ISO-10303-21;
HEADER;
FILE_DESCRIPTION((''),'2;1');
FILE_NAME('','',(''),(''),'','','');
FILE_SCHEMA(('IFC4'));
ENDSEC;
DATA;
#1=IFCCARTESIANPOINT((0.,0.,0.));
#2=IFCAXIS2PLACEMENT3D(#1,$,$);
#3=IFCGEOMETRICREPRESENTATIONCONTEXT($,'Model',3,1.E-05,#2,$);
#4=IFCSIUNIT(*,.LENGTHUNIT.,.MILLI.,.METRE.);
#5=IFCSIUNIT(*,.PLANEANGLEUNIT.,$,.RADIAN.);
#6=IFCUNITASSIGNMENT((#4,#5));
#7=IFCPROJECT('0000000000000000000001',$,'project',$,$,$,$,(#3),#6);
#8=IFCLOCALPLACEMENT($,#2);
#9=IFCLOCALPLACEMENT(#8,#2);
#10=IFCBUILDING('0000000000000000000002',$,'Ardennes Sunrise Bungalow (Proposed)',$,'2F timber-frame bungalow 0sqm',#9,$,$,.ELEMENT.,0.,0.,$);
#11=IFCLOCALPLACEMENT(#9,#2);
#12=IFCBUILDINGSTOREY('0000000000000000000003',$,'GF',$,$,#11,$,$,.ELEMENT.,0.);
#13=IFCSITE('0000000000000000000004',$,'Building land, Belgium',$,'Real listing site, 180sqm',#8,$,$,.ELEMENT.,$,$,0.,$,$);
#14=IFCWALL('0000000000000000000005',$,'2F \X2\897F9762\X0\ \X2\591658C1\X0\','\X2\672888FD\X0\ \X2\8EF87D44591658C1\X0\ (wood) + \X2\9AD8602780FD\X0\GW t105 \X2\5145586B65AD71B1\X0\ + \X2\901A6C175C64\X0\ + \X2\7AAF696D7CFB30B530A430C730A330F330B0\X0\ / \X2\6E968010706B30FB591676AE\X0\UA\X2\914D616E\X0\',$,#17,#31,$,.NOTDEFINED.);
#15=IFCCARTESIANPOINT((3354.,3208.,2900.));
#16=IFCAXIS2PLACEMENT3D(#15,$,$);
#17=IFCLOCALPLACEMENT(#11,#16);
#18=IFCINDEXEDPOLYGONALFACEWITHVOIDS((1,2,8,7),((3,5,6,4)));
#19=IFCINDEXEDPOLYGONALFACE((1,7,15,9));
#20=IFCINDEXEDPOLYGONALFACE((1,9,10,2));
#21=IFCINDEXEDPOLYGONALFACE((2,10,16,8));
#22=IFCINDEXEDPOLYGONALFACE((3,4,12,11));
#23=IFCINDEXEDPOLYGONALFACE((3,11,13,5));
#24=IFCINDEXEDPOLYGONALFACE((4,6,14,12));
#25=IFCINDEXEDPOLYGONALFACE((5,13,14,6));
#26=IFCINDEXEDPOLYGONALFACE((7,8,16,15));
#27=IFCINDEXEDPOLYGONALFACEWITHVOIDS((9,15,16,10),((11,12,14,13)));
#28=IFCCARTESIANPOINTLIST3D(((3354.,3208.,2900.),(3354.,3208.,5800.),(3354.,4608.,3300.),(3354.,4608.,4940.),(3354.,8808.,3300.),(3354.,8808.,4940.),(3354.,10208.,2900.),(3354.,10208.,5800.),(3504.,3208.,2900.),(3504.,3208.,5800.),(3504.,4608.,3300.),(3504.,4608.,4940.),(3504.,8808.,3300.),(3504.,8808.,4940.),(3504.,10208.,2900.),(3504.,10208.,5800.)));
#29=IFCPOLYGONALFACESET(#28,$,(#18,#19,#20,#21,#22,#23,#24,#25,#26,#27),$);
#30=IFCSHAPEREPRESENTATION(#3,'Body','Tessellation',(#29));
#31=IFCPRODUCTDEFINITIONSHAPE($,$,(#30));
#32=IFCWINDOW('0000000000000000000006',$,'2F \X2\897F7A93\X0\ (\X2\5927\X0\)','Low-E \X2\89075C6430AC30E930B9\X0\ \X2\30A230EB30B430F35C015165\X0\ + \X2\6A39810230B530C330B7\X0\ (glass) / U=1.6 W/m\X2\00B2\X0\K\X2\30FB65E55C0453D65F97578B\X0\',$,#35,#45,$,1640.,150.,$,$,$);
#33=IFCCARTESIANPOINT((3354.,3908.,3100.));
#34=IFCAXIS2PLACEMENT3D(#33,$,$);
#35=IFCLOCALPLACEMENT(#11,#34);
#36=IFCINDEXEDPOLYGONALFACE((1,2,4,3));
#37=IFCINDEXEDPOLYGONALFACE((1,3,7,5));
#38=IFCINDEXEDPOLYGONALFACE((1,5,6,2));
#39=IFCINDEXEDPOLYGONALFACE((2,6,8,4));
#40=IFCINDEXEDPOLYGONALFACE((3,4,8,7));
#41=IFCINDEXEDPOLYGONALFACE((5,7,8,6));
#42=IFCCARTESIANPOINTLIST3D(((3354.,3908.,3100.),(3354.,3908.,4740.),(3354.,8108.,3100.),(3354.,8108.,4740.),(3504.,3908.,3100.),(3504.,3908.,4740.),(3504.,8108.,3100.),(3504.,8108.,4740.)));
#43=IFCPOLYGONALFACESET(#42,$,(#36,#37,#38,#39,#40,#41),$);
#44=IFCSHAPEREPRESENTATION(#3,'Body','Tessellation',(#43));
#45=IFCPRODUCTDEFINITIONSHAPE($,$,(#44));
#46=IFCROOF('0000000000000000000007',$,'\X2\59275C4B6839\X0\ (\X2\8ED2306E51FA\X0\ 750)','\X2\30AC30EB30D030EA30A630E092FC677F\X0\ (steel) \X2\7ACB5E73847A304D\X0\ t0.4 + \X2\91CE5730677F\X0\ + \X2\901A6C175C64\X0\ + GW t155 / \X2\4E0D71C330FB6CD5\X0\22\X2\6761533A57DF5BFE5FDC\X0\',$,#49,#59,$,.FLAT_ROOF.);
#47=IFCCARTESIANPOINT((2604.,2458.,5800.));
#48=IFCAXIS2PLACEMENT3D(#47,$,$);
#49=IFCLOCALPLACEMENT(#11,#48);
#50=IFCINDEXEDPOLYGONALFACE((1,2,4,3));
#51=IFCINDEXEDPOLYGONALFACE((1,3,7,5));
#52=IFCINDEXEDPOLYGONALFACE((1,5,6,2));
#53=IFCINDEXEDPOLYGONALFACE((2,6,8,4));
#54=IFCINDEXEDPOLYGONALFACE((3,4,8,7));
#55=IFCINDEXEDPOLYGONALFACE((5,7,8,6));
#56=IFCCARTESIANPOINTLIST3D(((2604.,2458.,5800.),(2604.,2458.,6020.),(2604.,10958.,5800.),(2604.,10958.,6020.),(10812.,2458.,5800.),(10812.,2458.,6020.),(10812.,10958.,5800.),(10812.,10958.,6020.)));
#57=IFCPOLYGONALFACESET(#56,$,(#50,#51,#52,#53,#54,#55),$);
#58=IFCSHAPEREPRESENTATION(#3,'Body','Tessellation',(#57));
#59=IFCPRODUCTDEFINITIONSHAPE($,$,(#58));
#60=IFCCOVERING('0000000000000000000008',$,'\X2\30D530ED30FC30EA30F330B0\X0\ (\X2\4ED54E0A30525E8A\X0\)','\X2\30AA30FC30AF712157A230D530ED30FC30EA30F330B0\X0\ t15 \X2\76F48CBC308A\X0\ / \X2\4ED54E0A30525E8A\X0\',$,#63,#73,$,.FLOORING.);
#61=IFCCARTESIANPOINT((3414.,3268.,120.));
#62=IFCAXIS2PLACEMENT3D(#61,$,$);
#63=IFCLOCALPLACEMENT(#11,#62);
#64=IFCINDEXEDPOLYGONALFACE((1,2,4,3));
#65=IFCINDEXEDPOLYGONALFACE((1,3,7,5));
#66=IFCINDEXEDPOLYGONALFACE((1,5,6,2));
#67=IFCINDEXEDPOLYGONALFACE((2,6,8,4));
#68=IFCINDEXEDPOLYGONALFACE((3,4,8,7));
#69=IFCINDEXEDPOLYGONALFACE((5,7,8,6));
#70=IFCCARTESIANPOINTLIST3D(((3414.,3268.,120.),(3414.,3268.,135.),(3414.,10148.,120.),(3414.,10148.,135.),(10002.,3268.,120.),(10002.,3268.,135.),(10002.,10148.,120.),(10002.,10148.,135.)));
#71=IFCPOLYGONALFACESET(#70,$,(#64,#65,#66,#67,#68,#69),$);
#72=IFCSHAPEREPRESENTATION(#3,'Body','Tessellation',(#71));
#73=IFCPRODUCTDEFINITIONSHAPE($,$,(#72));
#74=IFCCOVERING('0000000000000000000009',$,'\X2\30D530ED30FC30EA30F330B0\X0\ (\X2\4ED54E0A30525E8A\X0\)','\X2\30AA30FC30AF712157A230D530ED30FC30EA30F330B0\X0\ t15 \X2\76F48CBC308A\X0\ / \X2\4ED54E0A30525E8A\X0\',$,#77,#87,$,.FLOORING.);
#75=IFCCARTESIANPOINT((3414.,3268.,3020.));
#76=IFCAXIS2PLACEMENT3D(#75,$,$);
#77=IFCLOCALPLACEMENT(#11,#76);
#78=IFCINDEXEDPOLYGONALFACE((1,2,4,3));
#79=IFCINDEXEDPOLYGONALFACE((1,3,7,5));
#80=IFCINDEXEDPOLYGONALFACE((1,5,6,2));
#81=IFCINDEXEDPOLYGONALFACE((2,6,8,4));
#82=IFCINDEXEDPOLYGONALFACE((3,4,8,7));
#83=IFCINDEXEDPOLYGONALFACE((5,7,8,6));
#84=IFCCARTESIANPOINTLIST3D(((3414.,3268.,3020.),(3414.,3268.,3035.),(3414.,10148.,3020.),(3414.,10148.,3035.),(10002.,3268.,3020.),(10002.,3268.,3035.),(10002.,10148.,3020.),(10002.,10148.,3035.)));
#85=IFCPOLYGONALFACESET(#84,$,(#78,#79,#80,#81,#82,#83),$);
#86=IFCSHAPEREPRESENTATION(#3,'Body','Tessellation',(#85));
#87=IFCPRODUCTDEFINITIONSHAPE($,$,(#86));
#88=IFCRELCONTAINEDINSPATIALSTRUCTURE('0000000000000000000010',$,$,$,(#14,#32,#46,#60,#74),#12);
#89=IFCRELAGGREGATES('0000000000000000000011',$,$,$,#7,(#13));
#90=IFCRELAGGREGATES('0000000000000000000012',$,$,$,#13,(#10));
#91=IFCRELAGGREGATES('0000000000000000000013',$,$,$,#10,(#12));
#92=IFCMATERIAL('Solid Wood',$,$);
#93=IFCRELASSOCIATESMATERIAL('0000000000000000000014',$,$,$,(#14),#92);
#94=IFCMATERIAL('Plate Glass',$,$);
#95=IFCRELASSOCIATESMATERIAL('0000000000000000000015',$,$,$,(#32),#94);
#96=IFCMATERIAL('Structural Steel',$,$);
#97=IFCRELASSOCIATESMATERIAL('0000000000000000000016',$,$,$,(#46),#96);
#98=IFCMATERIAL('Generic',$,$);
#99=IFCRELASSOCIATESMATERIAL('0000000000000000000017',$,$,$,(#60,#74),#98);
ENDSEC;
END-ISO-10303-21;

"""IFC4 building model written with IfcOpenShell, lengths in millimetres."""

from ifc_helpers import new_model, si_unit, frame, frame_2d, origin, place, context, project, spatial, rectangle, extrude, material, element, fill, save


model = new_model("IFC4")

# Units and contexts
model_context = context("Model", 3, precision=1e-05, world=origin())
ifc_project = project(units=[si_unit("LENGTHUNIT", "METRE", prefix="MILLI"), si_unit("PLANEANGLEUNIT", "RADIAN")], contexts=[model_context])

# Site, building, storey
site_placement = place(None, origin())
site = spatial("IfcSite", under=ifc_project, at=site_placement, Name="Building land, Belgium", ObjectType="Real listing site, 180sqm", CompositionType="ELEMENT", RefElevation=0.0)
building_placement = place(site_placement, origin())
building = spatial("IfcBuilding", under=site, at=building_placement, Name="Ardennes Sunrise Bungalow (Proposed)", ObjectType="2F timber-frame bungalow 0sqm", CompositionType="ELEMENT", ElevationOfRefHeight=0.0, ElevationOfTerrain=0.0)
storey_placement = place(building_placement, origin())
storey = spatial("IfcBuildingStorey", under=building, at=storey_placement, Name="GF", CompositionType="ELEMENT", Elevation=0.0)

# Shared definitions
ifc_material_1 = material(Name="Solid Wood")

# Shared definitions
ifc_material_2 = material(Name="Plate Glass")

# Wall, opening, window
wall_1_placement = place(storey_placement, frame((3354.0, 3208.0, 2900.0)))
wall_1 = element("IfcWall", 1, at=wall_1_placement, inside=storey, material=ifc_material_1, Name="2F 西面 外壁", Description="木製 軸組外壁 (wood) + 高性能GW t105 充填断熱 + 通気層 + 窯業系サイディング / 準耐火・外皮UA配慮", PredefinedType="NOTDEFINED", context=model_context, shape_type="SweptSolid", body=[
    extrude(rectangle(XDim=150.0, YDim=7000.0, at=frame_2d((75.0, 3500.0))), frame((3354.0, 3208.0, 2900.0)), (0.0, 0.0, 1.0), 2900.0),
])
opening_1_placement = place(storey_placement, frame((3354.0, 3908.0, 3100.0)))
opening_1 = element("IfcOpeningElement", 2, at=opening_1_placement, cuts=wall_1, PredefinedType="NOTDEFINED", context=model_context, shape_type="SweptSolid", body=[
    extrude(rectangle(XDim=150.0, YDim=4200.0, at=frame_2d((75.0, 2100.0))), frame((3354.0, 3908.0, 3100.0)), (0.0, 0.0, 1.0), 1640.0),
])
window_1_placement = place(storey_placement, frame((3354.0, 3908.0, 3100.0)))
window_1 = element("IfcWindow", 3, at=window_1_placement, inside=storey, material=ifc_material_2, Name="2F 西窓 (大)", Description="Low-E 複層ガラス アルゴン封入 + 樹脂サッシ (glass) / U=1.6 W/m²K・日射取得型", OverallHeight=1640.0, OverallWidth=150.0, context=model_context, shape_type="SweptSolid", body=[
    extrude(rectangle(XDim=150.0, YDim=4200.0, at=frame_2d((75.0, 2100.0))), frame((3354.0, 3908.0, 3100.0)), (0.0, 0.0, 1.0), 1640.0),
])
fill(opening_1, window_1)

# Roof
ifc_material_3 = material(Name="Structural Steel")
roof_placement = place(storey_placement, frame((2604.0, 2458.0, 5800.0)))
element("IfcRoof", 4, at=roof_placement, inside=storey, material=ifc_material_3, Name="大屋根 (軒の出 750)", Description="ガルバリウム鋼板 (steel) 立平葺き t0.4 + 野地板 + 通気層 + GW t155 / 不燃・法22条区域対応", PredefinedType="FLAT_ROOF", context=model_context, shape_type="SweptSolid", body=[
    extrude(rectangle(XDim=8208.0, YDim=8500.0, at=frame_2d((4104.0, 4250.0))), frame((2604.0, 2458.0, 5800.0)), (0.0, 0.0, 1.0), 220.0),
])

# Coverings
ifc_material_4 = material(Name="Generic")
covering_1_placement = place(storey_placement, frame((3414.0, 3268.0, 120.0)))
element("IfcCovering", 5, at=covering_1_placement, inside=storey, material=ifc_material_4, Name="フローリング (仕上げ床)", Description="オーク無垢フローリング t15 直貼り / 仕上げ床", PredefinedType="FLOORING", context=model_context, shape_type="SweptSolid", body=[
    extrude(rectangle(XDim=6588.0, YDim=6880.0, at=frame_2d((3294.0, 3440.0))), frame((3414.0, 3268.0, 120.0)), (0.0, 0.0, 1.0), 15.0),
])
covering_2_placement = place(storey_placement, frame((3414.0, 3268.0, 3020.0)))
element("IfcCovering", 6, at=covering_2_placement, inside=storey, material=ifc_material_4, Name="フローリング (仕上げ床)", Description="オーク無垢フローリング t15 直貼り / 仕上げ床", PredefinedType="FLOORING", context=model_context, shape_type="SweptSolid", body=[
    extrude(rectangle(XDim=6588.0, YDim=6880.0, at=frame_2d((3294.0, 3440.0))), frame((3414.0, 3268.0, 3020.0)), (0.0, 0.0, 1.0), 15.0),
])

save(model, "model.ifc")
